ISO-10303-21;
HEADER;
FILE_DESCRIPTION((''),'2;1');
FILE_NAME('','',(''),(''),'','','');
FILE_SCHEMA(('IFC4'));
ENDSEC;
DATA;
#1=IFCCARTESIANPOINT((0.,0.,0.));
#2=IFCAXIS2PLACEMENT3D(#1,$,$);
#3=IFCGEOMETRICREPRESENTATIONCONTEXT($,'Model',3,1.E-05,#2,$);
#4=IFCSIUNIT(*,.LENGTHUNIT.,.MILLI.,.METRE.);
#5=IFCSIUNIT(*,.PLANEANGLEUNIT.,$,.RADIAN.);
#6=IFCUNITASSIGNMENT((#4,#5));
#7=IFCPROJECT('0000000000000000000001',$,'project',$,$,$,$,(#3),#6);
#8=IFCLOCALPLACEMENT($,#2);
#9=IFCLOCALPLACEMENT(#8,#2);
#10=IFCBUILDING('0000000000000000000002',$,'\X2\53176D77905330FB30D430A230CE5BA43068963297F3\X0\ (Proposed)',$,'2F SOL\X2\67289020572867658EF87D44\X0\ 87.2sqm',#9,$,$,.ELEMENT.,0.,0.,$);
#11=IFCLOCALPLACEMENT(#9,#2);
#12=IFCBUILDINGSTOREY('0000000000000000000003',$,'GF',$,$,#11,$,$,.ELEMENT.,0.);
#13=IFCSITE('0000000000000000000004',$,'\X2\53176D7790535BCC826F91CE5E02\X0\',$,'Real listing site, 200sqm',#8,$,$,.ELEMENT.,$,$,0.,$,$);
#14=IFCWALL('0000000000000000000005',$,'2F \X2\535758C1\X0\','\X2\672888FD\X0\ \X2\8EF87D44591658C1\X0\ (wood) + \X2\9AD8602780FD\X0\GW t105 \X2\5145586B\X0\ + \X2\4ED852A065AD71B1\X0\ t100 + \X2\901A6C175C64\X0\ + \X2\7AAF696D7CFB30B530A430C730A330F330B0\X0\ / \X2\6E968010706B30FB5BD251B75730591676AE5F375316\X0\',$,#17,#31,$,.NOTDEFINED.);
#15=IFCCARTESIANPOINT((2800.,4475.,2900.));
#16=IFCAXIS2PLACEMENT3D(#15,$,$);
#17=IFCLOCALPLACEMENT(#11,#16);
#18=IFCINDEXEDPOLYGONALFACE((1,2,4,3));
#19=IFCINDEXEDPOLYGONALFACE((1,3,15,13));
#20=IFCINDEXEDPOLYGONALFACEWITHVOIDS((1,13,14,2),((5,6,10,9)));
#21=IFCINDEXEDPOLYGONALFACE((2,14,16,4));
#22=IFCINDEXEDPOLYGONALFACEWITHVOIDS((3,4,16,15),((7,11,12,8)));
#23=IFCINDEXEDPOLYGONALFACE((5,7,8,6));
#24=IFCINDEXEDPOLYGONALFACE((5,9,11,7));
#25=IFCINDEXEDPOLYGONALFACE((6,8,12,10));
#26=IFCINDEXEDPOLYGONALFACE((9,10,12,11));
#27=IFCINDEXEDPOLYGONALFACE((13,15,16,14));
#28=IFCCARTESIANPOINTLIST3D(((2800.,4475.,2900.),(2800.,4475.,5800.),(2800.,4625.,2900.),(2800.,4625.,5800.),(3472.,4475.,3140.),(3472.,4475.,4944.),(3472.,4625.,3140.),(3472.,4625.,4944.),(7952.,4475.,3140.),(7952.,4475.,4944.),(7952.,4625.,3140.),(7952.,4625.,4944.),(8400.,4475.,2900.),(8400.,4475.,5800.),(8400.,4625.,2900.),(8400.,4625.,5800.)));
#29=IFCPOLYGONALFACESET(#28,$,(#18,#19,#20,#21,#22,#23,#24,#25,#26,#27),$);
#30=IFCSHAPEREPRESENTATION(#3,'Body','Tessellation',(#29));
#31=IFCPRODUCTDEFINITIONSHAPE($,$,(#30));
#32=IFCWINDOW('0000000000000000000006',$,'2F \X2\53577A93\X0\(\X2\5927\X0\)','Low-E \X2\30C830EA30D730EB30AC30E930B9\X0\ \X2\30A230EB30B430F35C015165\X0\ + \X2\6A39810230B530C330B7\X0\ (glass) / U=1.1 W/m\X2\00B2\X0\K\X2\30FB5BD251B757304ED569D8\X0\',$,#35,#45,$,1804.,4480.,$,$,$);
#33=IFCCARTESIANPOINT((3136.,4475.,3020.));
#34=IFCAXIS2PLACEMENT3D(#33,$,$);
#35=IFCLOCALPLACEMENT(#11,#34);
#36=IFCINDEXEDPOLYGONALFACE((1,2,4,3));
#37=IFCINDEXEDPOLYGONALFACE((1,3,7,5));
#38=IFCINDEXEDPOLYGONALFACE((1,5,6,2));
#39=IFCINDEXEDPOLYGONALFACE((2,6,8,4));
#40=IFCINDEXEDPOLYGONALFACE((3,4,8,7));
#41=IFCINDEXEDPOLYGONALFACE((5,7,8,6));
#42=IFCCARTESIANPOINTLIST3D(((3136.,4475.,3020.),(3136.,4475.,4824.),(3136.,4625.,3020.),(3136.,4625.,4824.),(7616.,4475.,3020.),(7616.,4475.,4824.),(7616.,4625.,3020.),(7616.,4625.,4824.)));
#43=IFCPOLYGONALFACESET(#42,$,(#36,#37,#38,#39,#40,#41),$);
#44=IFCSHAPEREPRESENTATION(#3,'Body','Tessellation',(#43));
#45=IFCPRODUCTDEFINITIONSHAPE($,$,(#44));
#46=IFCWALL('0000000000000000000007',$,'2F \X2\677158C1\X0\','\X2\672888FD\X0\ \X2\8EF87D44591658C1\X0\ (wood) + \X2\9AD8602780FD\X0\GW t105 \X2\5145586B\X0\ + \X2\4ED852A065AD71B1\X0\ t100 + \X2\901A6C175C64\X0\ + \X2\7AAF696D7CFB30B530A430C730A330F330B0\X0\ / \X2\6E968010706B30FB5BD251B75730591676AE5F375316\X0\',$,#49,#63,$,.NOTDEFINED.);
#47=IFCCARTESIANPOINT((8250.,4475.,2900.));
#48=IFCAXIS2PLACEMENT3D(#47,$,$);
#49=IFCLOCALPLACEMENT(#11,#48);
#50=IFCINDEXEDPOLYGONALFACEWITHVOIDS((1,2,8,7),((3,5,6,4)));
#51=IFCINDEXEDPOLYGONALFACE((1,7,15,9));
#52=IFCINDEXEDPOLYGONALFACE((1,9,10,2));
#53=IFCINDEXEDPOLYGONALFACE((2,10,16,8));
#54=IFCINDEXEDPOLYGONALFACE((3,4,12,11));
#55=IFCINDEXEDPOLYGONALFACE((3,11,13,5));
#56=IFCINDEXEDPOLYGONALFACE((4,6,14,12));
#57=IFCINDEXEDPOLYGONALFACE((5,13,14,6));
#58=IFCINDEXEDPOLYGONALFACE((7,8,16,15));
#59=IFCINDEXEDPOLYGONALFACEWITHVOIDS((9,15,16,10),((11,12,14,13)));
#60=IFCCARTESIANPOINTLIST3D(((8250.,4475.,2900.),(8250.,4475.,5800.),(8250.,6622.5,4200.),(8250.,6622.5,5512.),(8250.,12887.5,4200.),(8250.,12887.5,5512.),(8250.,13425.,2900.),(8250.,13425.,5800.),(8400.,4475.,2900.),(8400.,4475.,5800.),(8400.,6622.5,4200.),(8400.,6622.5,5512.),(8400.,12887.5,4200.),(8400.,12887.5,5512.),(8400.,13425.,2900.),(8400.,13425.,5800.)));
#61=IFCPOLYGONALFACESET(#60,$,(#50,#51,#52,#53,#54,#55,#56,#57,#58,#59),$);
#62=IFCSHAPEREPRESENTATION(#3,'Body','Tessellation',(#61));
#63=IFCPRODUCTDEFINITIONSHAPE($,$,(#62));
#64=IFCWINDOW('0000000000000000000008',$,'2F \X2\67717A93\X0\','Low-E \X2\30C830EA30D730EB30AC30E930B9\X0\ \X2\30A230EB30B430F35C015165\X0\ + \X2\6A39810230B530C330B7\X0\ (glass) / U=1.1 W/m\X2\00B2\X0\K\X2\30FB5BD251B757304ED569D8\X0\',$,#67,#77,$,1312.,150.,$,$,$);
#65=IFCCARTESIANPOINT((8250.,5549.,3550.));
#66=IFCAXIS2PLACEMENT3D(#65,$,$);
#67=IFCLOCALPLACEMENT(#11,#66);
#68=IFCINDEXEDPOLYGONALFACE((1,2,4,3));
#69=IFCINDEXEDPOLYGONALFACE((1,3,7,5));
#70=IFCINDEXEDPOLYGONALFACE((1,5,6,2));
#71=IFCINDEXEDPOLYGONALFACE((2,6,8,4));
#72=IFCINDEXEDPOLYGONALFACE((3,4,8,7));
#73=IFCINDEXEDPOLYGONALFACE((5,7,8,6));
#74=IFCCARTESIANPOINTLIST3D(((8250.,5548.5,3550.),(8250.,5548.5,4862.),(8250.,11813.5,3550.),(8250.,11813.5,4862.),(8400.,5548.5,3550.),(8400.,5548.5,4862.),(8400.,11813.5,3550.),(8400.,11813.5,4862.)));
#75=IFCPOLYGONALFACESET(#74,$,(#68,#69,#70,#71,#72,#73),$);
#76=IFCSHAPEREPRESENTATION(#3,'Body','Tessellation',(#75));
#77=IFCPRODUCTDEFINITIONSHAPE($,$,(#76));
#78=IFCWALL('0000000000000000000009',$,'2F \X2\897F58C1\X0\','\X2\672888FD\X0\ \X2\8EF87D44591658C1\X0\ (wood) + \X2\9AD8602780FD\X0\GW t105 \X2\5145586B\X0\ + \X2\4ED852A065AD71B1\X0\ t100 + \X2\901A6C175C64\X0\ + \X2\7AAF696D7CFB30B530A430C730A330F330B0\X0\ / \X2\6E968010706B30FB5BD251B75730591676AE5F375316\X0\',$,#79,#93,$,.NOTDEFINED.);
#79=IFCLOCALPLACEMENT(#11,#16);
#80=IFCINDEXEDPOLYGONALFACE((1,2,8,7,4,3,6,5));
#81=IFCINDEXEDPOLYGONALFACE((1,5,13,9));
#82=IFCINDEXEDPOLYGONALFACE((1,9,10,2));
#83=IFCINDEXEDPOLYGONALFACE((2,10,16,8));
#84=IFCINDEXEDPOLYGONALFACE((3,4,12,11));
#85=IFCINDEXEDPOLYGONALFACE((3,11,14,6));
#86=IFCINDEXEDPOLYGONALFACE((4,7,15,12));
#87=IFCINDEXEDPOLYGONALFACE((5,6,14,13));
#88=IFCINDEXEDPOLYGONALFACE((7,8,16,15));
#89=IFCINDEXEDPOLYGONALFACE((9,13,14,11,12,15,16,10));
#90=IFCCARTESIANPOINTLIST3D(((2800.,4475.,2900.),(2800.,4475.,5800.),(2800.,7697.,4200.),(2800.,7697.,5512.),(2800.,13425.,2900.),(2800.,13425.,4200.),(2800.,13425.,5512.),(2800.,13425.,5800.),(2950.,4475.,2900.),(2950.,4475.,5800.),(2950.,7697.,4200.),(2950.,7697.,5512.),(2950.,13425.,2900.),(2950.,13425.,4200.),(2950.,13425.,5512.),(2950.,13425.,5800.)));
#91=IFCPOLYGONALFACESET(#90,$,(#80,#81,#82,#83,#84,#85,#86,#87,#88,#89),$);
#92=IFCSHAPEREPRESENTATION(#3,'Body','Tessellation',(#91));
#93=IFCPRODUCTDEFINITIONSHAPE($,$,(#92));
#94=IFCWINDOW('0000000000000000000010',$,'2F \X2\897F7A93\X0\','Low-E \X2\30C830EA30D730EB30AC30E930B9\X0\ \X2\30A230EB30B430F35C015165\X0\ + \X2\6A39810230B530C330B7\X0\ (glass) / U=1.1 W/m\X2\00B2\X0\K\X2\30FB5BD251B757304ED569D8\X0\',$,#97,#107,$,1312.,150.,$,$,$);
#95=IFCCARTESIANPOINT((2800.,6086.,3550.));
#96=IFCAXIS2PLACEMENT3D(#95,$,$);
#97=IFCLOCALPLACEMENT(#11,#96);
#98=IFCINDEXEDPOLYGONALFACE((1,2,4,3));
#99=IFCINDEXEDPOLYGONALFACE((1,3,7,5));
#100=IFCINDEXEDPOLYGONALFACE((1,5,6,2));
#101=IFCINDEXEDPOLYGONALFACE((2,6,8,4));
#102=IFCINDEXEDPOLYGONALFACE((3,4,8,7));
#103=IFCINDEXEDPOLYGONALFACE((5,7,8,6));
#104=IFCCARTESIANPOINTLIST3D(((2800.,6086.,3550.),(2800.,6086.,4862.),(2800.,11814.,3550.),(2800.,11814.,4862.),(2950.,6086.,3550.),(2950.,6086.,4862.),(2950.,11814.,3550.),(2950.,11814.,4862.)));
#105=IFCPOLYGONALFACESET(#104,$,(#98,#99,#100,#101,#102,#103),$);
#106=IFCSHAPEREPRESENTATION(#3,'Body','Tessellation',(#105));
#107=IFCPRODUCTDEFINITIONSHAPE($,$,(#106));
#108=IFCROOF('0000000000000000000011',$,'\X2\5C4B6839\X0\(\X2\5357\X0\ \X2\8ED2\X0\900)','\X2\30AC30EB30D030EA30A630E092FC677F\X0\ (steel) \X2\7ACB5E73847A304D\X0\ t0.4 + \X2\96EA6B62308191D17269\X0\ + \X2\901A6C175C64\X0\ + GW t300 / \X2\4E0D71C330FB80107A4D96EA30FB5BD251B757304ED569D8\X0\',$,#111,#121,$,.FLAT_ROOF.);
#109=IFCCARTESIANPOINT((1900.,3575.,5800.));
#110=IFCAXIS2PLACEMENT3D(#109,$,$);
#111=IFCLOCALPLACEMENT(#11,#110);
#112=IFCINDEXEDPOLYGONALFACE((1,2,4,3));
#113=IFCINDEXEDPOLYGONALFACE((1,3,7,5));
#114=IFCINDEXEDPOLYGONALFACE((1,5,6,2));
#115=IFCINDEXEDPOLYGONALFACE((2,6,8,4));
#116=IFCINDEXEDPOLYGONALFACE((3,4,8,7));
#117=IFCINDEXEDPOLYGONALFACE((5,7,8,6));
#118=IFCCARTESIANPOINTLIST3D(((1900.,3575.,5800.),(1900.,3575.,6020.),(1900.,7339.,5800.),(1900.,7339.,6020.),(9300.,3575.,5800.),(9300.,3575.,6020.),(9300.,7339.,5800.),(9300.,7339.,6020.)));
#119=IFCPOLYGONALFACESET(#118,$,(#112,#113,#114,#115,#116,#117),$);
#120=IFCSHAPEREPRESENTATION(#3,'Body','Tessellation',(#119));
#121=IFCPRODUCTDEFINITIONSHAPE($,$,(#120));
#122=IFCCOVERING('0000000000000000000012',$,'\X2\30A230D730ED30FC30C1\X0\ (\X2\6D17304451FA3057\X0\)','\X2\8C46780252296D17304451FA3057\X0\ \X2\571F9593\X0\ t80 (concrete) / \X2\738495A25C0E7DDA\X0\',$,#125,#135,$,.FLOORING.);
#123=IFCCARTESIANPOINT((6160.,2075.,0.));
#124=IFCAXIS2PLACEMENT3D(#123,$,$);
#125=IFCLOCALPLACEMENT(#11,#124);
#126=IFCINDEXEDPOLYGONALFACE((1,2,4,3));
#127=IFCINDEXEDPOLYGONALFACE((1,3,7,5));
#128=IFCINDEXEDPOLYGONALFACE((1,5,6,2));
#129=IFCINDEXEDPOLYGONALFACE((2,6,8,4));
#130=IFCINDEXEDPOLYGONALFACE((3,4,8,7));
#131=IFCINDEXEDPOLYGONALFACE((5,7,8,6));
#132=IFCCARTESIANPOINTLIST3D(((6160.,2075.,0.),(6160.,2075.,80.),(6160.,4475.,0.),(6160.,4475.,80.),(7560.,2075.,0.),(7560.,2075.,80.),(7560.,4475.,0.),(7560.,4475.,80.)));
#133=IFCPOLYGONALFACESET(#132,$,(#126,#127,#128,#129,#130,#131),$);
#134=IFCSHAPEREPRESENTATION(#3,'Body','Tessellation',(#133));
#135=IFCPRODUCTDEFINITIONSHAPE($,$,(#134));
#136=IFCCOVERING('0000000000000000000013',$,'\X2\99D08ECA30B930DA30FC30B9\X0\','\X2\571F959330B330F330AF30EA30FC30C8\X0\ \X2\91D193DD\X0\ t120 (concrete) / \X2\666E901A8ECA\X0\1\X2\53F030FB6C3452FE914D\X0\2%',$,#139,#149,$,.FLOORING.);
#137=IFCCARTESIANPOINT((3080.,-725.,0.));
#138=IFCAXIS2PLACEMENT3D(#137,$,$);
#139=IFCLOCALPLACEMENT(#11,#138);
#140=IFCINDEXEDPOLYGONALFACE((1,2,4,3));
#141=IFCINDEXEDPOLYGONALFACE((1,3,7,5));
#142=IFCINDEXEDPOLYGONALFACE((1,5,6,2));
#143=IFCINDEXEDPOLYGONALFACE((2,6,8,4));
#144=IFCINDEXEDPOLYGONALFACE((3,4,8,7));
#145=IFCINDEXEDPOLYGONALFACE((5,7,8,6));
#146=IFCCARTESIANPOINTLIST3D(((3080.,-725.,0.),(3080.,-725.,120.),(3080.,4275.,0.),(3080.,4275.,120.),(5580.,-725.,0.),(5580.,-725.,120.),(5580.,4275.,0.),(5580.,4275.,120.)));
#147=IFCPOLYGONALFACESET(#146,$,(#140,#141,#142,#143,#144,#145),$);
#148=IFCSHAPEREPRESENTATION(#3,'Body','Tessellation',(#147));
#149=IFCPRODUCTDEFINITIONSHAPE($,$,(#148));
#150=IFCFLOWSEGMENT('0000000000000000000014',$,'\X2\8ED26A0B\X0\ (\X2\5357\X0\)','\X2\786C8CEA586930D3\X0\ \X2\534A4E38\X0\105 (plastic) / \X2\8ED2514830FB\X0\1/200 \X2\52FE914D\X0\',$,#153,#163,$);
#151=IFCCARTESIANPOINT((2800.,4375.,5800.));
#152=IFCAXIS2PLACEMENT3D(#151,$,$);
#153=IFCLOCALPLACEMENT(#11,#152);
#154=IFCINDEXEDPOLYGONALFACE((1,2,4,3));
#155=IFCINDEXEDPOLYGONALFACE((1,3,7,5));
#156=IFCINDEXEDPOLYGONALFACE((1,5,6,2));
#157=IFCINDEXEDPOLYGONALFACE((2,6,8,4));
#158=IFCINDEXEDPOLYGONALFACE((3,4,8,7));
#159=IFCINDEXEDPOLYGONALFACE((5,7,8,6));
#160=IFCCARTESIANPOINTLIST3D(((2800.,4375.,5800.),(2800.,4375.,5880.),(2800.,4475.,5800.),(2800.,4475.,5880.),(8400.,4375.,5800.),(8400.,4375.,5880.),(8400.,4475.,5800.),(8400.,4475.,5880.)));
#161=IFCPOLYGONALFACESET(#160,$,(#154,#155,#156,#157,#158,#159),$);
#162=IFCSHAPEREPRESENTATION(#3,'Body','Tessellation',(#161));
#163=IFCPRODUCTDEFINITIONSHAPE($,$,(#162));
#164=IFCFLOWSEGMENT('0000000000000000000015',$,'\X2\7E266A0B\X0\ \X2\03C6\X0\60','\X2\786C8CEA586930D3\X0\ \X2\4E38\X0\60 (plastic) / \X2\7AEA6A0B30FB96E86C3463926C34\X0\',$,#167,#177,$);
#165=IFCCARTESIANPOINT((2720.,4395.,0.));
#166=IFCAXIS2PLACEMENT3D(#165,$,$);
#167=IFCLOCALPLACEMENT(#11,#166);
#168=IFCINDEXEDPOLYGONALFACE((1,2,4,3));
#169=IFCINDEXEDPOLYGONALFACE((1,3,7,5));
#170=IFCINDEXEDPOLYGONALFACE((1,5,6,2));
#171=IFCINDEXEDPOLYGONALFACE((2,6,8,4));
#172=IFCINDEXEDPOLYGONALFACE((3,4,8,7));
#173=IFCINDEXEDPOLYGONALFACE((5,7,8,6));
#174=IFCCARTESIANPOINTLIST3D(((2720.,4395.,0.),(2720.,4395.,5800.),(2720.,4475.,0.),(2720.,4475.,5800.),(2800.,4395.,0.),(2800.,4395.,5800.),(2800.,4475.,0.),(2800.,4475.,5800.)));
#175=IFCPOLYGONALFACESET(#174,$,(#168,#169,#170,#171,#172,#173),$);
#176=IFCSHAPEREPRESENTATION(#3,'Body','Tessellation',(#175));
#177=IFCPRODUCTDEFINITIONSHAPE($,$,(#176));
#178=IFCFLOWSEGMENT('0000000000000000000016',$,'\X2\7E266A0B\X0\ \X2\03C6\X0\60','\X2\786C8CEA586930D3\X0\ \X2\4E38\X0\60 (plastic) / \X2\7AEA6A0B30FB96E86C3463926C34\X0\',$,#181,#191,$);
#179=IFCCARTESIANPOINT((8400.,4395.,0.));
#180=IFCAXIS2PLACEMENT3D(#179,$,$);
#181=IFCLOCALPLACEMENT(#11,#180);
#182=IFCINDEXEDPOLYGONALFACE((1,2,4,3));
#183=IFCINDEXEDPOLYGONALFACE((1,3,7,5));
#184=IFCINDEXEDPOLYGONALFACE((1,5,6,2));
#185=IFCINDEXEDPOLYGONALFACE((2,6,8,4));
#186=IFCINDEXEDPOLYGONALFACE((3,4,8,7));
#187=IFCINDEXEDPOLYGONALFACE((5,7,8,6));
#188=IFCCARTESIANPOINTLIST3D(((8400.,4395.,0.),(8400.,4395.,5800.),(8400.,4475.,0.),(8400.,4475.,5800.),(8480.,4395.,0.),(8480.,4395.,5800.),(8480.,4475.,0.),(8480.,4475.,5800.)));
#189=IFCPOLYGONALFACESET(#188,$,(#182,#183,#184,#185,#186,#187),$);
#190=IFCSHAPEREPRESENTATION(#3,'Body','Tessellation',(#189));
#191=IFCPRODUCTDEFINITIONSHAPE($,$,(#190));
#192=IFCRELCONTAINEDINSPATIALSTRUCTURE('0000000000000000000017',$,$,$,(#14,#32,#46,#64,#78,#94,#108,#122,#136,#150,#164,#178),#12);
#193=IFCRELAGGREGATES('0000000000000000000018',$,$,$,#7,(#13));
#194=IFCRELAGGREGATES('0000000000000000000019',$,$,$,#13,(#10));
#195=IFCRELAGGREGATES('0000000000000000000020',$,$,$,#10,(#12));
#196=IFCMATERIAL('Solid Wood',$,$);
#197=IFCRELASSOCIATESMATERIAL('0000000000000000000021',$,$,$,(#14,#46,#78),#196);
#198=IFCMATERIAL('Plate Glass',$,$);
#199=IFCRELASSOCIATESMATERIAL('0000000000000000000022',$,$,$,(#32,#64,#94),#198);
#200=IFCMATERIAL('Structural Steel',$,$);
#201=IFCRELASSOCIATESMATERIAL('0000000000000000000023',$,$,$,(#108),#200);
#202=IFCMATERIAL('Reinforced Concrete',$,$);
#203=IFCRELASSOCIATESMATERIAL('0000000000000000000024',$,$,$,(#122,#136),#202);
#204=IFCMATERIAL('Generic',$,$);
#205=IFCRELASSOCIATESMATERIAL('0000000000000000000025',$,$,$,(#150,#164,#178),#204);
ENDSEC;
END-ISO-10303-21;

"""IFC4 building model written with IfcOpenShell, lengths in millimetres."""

from ifc_helpers import new_model, si_unit, frame, frame_2d, origin, place, context, project, spatial, rectangle, extrude, material, element, fill, save


model = new_model("IFC4")

# Units and contexts
model_context = context("Model", 3, precision=1e-05, world=origin())
ifc_project = project(units=[si_unit("LENGTHUNIT", "METRE", prefix="MILLI"), si_unit("PLANEANGLEUNIT", "RADIAN")], contexts=[model_context])

# Site, building, storey
site_placement = place(None, origin())
site = spatial("IfcSite", under=ifc_project, at=site_placement, Name="北海道富良野市", ObjectType="Real listing site, 200sqm", CompositionType="ELEMENT", RefElevation=0.0)
building_placement = place(site_placement, origin())
building = spatial("IfcBuilding", under=site, at=building_placement, Name="北海道・ピアノ室と防音 (Proposed)", ObjectType="2F SOL木造在来軸組 87.2sqm", CompositionType="ELEMENT", ElevationOfRefHeight=0.0, ElevationOfTerrain=0.0)
storey_placement = place(building_placement, origin())
storey = spatial("IfcBuildingStorey", under=building, at=storey_placement, Name="GF", CompositionType="ELEMENT", Elevation=0.0)

# Shared definitions
ifc_material_1 = material(Name="Solid Wood")

# Shared definitions
ifc_material_2 = material(Name="Reinforced Concrete")

# Shared definitions
ifc_material_3 = material(Name="Plate Glass")

# Walls, openings, windows
wall_1_placement = place(storey_placement, frame((2800.0, 4475.0, 2900.0)))
wall_1 = element("IfcWall", 1, at=wall_1_placement, inside=storey, material=ifc_material_1, Name="2F 南壁", Description="木製 軸組外壁 (wood) + 高性能GW t105 充填 + 付加断熱 t100 + 通気層 + 窯業系サイディング / 準耐火・寒冷地外皮強化", PredefinedType="NOTDEFINED", context=model_context, shape_type="SweptSolid", body=[
    extrude(rectangle(XDim=5600.0, YDim=150.0, at=frame_2d((2800.0, 75.0))), frame((2800.0, 4475.0, 2900.0)), (0.0, 0.0, 1.0), 2900.0),
])
opening_1_placement = place(storey_placement, frame((3136.0, 4475.0, 3020.0)))
opening_1 = element("IfcOpeningElement", 2, at=opening_1_placement, cuts=wall_1, PredefinedType="NOTDEFINED", context=model_context, shape_type="SweptSolid", body=[
    extrude(rectangle(XDim=4480.0, YDim=150.0, at=frame_2d((2240.0, 75.0))), frame((3136.0, 4475.0, 3020.0)), (0.0, 0.0, 1.0), 1804.0),
])
window_1_placement = place(storey_placement, frame((3136.0, 4475.0, 3020.0)))
window_1 = element("IfcWindow", 3, at=window_1_placement, inside=storey, material=ifc_material_3, Name="2F 南窓(大)", Description="Low-E トリプルガラス アルゴン封入 + 樹脂サッシ (glass) / U=1.1 W/m²K・寒冷地仕様", OverallHeight=1804.0, OverallWidth=4480.0, context=model_context, shape_type="SweptSolid", body=[
    extrude(rectangle(XDim=4480.0, YDim=150.0, at=frame_2d((2240.0, 75.0))), frame((3136.0, 4475.0, 3020.0)), (0.0, 0.0, 1.0), 1804.0),
])
fill(opening_1, window_1)
wall_2_placement = place(storey_placement, frame((8250.0, 4475.0, 2900.0)))
wall_2 = element("IfcWall", 4, at=wall_2_placement, inside=storey, material=ifc_material_1, Name="2F 東壁", Description="木製 軸組外壁 (wood) + 高性能GW t105 充填 + 付加断熱 t100 + 通気層 + 窯業系サイディング / 準耐火・寒冷地外皮強化", PredefinedType="NOTDEFINED", context=model_context, shape_type="SweptSolid", body=[
    extrude(rectangle(XDim=150.0, YDim=8950.0, at=frame_2d((75.0, 4475.0))), frame((8250.0, 4475.0, 2900.0)), (0.0, 0.0, 1.0), 2900.0),
])
opening_2_placement = place(storey_placement, frame((8250.0, 5549.0, 3550.0)))
opening_2 = element("IfcOpeningElement", 5, at=opening_2_placement, cuts=wall_2, PredefinedType="NOTDEFINED", context=model_context, shape_type="SweptSolid", body=[
    extrude(rectangle(XDim=150.0, YDim=6265.0, at=frame_2d((75.0, 3132.0))), frame((8250.0, 5549.0, 3550.0)), (0.0, 0.0, 1.0), 1312.0),
])
window_2_placement = place(storey_placement, frame((8250.0, 5549.0, 3550.0)))
window_2 = element("IfcWindow", 6, at=window_2_placement, inside=storey, material=ifc_material_3, Name="2F 東窓", Description="Low-E トリプルガラス アルゴン封入 + 樹脂サッシ (glass) / U=1.1 W/m²K・寒冷地仕様", OverallHeight=1312.0, OverallWidth=150.0, context=model_context, shape_type="SweptSolid", body=[
    extrude(rectangle(XDim=150.0, YDim=6265.0, at=frame_2d((75.0, 3132.0))), frame((8250.0, 5549.0, 3550.0)), (0.0, 0.0, 1.0), 1312.0),
])
fill(opening_2, window_2)
wall_3_placement = place(storey_placement, frame((2800.0, 4475.0, 2900.0)))
wall_3 = element("IfcWall", 7, at=wall_3_placement, inside=storey, material=ifc_material_1, Name="2F 西壁", Description="木製 軸組外壁 (wood) + 高性能GW t105 充填 + 付加断熱 t100 + 通気層 + 窯業系サイディング / 準耐火・寒冷地外皮強化", PredefinedType="NOTDEFINED", context=model_context, shape_type="SweptSolid", body=[
    extrude(rectangle(XDim=150.0, YDim=8950.0, at=frame_2d((75.0, 4475.0))), frame((2800.0, 4475.0, 2900.0)), (0.0, 0.0, 1.0), 2900.0),
])
opening_3_placement = place(storey_placement, frame((2800.0, 6086.0, 3550.0)))
opening_3 = element("IfcOpeningElement", 8, at=opening_3_placement, cuts=wall_3, PredefinedType="NOTDEFINED", context=model_context, shape_type="SweptSolid", body=[
    extrude(rectangle(XDim=150.0, YDim=5728.0, at=frame_2d((75.0, 2864.0))), frame((2800.0, 6086.0, 3550.0)), (0.0, 0.0, 1.0), 1312.0),
])
window_3_placement = place(storey_placement, frame((2800.0, 6086.0, 3550.0)))
window_3 = element("IfcWindow", 9, at=window_3_placement, inside=storey, material=ifc_material_3, Name="2F 西窓", Description="Low-E トリプルガラス アルゴン封入 + 樹脂サッシ (glass) / U=1.1 W/m²K・寒冷地仕様", OverallHeight=1312.0, OverallWidth=150.0, context=model_context, shape_type="SweptSolid", body=[
    extrude(rectangle(XDim=150.0, YDim=5728.0, at=frame_2d((75.0, 2864.0))), frame((2800.0, 6086.0, 3550.0)), (0.0, 0.0, 1.0), 1312.0),
])
fill(opening_3, window_3)

# Roof
ifc_material_4 = material(Name="Structural Steel")
for number, where, name in (
    (10, (1900.0, 3575.0, 5800.0), "屋根(南 軒900)"),
):
    element("IfcRoof", number, at=place(storey_placement, frame(where)), inside=storey, material=ifc_material_4, Name=name, Description="ガルバリウム鋼板 (steel) 立平葺き t0.4 + 雪止め金物 + 通気層 + GW t300 / 不燃・耐積雪・寒冷地仕様", PredefinedType="FLAT_ROOF", context=model_context, shape_type="SweptSolid", body=[
        extrude(rectangle(XDim=7400.0, YDim=3764.0, at=frame_2d((3700.0, 1882.0))), frame((1900.0, 3575.0, 5800.0)), (0.0, 0.0, 1.0), 220.0),
    ])

# Coverings
covering_1_placement = place(storey_placement, frame((6160.0, 2075.0, 0.0)))
element("IfcCovering", 11, at=covering_1_placement, inside=storey, material=ifc_material_2, Name="アプローチ (洗い出し)", Description="豆砂利洗い出し 土間 t80 (concrete) / 玄関導線", PredefinedType="FLOORING", context=model_context, shape_type="SweptSolid", body=[
    extrude(rectangle(XDim=1400.0, YDim=2400.0, at=frame_2d((700.0, 1200.0))), frame((6160.0, 2075.0, 0.0)), (0.0, 0.0, 1.0), 80.0),
])
covering_2_placement = place(storey_placement, frame((3080.0, -725.0, 0.0)))
element("IfcCovering", 12, at=covering_2_placement, inside=storey, material=ifc_material_2, Name="駐車スペース", Description="土間コンクリート 金鏝 t120 (concrete) / 普通車1台・水勾配2%", PredefinedType="FLOORING", context=model_context, shape_type="SweptSolid", body=[
    extrude(rectangle(XDim=2500.0, YDim=5000.0, at=frame_2d((1250.0, 2500.0))), frame((3080.0, -725.0, 0.0)), (0.0, 0.0, 1.0), 120.0),
])

# Flow segments
ifc_material_5 = material(Name="Generic")
flow_segment_1_placement = place(storey_placement, frame((2800.0, 4375.0, 5800.0)))
element("IfcFlowSegment", 13, at=flow_segment_1_placement, inside=storey, material=ifc_material_5, Name="軒樋 (南)", Description="硬質塩ビ 半丸105 (plastic) / 軒先・1/200 勾配", context=model_context, shape_type="SweptSolid", body=[
    extrude(rectangle(XDim=5600.0, YDim=100.0, at=frame_2d((2800.0, 50.0))), frame((2800.0, 4375.0, 5800.0)), (0.0, 0.0, 1.0), 80.0),
])
flow_segment_2_placement = place(storey_placement, frame((2720.0, 4395.0, 0.0)))
element("IfcFlowSegment", 14, at=flow_segment_2_placement, inside=storey, material=ifc_material_5, Name="縦樋 φ60", Description="硬質塩ビ 丸60 (plastic) / 竪樋・雨水排水", context=model_context, shape_type="SweptSolid", body=[
    extrude(rectangle(XDim=80.0, YDim=80.0, at=frame_2d((40.0, 40.0))), frame((2720.0, 4395.0, 0.0)), (0.0, 0.0, 1.0), 5800.0),
])
flow_segment_3_placement = place(storey_placement, frame((8400.0, 4395.0, 0.0)))
element("IfcFlowSegment", 15, at=flow_segment_3_placement, inside=storey, material=ifc_material_5, Name="縦樋 φ60", Description="硬質塩ビ 丸60 (plastic) / 竪樋・雨水排水", context=model_context, shape_type="SweptSolid", body=[
    extrude(rectangle(XDim=80.0, YDim=80.0, at=frame_2d((40.0, 40.0))), frame((8400.0, 4395.0, 0.0)), (0.0, 0.0, 1.0), 5800.0),
])

save(model, "model.ifc")
